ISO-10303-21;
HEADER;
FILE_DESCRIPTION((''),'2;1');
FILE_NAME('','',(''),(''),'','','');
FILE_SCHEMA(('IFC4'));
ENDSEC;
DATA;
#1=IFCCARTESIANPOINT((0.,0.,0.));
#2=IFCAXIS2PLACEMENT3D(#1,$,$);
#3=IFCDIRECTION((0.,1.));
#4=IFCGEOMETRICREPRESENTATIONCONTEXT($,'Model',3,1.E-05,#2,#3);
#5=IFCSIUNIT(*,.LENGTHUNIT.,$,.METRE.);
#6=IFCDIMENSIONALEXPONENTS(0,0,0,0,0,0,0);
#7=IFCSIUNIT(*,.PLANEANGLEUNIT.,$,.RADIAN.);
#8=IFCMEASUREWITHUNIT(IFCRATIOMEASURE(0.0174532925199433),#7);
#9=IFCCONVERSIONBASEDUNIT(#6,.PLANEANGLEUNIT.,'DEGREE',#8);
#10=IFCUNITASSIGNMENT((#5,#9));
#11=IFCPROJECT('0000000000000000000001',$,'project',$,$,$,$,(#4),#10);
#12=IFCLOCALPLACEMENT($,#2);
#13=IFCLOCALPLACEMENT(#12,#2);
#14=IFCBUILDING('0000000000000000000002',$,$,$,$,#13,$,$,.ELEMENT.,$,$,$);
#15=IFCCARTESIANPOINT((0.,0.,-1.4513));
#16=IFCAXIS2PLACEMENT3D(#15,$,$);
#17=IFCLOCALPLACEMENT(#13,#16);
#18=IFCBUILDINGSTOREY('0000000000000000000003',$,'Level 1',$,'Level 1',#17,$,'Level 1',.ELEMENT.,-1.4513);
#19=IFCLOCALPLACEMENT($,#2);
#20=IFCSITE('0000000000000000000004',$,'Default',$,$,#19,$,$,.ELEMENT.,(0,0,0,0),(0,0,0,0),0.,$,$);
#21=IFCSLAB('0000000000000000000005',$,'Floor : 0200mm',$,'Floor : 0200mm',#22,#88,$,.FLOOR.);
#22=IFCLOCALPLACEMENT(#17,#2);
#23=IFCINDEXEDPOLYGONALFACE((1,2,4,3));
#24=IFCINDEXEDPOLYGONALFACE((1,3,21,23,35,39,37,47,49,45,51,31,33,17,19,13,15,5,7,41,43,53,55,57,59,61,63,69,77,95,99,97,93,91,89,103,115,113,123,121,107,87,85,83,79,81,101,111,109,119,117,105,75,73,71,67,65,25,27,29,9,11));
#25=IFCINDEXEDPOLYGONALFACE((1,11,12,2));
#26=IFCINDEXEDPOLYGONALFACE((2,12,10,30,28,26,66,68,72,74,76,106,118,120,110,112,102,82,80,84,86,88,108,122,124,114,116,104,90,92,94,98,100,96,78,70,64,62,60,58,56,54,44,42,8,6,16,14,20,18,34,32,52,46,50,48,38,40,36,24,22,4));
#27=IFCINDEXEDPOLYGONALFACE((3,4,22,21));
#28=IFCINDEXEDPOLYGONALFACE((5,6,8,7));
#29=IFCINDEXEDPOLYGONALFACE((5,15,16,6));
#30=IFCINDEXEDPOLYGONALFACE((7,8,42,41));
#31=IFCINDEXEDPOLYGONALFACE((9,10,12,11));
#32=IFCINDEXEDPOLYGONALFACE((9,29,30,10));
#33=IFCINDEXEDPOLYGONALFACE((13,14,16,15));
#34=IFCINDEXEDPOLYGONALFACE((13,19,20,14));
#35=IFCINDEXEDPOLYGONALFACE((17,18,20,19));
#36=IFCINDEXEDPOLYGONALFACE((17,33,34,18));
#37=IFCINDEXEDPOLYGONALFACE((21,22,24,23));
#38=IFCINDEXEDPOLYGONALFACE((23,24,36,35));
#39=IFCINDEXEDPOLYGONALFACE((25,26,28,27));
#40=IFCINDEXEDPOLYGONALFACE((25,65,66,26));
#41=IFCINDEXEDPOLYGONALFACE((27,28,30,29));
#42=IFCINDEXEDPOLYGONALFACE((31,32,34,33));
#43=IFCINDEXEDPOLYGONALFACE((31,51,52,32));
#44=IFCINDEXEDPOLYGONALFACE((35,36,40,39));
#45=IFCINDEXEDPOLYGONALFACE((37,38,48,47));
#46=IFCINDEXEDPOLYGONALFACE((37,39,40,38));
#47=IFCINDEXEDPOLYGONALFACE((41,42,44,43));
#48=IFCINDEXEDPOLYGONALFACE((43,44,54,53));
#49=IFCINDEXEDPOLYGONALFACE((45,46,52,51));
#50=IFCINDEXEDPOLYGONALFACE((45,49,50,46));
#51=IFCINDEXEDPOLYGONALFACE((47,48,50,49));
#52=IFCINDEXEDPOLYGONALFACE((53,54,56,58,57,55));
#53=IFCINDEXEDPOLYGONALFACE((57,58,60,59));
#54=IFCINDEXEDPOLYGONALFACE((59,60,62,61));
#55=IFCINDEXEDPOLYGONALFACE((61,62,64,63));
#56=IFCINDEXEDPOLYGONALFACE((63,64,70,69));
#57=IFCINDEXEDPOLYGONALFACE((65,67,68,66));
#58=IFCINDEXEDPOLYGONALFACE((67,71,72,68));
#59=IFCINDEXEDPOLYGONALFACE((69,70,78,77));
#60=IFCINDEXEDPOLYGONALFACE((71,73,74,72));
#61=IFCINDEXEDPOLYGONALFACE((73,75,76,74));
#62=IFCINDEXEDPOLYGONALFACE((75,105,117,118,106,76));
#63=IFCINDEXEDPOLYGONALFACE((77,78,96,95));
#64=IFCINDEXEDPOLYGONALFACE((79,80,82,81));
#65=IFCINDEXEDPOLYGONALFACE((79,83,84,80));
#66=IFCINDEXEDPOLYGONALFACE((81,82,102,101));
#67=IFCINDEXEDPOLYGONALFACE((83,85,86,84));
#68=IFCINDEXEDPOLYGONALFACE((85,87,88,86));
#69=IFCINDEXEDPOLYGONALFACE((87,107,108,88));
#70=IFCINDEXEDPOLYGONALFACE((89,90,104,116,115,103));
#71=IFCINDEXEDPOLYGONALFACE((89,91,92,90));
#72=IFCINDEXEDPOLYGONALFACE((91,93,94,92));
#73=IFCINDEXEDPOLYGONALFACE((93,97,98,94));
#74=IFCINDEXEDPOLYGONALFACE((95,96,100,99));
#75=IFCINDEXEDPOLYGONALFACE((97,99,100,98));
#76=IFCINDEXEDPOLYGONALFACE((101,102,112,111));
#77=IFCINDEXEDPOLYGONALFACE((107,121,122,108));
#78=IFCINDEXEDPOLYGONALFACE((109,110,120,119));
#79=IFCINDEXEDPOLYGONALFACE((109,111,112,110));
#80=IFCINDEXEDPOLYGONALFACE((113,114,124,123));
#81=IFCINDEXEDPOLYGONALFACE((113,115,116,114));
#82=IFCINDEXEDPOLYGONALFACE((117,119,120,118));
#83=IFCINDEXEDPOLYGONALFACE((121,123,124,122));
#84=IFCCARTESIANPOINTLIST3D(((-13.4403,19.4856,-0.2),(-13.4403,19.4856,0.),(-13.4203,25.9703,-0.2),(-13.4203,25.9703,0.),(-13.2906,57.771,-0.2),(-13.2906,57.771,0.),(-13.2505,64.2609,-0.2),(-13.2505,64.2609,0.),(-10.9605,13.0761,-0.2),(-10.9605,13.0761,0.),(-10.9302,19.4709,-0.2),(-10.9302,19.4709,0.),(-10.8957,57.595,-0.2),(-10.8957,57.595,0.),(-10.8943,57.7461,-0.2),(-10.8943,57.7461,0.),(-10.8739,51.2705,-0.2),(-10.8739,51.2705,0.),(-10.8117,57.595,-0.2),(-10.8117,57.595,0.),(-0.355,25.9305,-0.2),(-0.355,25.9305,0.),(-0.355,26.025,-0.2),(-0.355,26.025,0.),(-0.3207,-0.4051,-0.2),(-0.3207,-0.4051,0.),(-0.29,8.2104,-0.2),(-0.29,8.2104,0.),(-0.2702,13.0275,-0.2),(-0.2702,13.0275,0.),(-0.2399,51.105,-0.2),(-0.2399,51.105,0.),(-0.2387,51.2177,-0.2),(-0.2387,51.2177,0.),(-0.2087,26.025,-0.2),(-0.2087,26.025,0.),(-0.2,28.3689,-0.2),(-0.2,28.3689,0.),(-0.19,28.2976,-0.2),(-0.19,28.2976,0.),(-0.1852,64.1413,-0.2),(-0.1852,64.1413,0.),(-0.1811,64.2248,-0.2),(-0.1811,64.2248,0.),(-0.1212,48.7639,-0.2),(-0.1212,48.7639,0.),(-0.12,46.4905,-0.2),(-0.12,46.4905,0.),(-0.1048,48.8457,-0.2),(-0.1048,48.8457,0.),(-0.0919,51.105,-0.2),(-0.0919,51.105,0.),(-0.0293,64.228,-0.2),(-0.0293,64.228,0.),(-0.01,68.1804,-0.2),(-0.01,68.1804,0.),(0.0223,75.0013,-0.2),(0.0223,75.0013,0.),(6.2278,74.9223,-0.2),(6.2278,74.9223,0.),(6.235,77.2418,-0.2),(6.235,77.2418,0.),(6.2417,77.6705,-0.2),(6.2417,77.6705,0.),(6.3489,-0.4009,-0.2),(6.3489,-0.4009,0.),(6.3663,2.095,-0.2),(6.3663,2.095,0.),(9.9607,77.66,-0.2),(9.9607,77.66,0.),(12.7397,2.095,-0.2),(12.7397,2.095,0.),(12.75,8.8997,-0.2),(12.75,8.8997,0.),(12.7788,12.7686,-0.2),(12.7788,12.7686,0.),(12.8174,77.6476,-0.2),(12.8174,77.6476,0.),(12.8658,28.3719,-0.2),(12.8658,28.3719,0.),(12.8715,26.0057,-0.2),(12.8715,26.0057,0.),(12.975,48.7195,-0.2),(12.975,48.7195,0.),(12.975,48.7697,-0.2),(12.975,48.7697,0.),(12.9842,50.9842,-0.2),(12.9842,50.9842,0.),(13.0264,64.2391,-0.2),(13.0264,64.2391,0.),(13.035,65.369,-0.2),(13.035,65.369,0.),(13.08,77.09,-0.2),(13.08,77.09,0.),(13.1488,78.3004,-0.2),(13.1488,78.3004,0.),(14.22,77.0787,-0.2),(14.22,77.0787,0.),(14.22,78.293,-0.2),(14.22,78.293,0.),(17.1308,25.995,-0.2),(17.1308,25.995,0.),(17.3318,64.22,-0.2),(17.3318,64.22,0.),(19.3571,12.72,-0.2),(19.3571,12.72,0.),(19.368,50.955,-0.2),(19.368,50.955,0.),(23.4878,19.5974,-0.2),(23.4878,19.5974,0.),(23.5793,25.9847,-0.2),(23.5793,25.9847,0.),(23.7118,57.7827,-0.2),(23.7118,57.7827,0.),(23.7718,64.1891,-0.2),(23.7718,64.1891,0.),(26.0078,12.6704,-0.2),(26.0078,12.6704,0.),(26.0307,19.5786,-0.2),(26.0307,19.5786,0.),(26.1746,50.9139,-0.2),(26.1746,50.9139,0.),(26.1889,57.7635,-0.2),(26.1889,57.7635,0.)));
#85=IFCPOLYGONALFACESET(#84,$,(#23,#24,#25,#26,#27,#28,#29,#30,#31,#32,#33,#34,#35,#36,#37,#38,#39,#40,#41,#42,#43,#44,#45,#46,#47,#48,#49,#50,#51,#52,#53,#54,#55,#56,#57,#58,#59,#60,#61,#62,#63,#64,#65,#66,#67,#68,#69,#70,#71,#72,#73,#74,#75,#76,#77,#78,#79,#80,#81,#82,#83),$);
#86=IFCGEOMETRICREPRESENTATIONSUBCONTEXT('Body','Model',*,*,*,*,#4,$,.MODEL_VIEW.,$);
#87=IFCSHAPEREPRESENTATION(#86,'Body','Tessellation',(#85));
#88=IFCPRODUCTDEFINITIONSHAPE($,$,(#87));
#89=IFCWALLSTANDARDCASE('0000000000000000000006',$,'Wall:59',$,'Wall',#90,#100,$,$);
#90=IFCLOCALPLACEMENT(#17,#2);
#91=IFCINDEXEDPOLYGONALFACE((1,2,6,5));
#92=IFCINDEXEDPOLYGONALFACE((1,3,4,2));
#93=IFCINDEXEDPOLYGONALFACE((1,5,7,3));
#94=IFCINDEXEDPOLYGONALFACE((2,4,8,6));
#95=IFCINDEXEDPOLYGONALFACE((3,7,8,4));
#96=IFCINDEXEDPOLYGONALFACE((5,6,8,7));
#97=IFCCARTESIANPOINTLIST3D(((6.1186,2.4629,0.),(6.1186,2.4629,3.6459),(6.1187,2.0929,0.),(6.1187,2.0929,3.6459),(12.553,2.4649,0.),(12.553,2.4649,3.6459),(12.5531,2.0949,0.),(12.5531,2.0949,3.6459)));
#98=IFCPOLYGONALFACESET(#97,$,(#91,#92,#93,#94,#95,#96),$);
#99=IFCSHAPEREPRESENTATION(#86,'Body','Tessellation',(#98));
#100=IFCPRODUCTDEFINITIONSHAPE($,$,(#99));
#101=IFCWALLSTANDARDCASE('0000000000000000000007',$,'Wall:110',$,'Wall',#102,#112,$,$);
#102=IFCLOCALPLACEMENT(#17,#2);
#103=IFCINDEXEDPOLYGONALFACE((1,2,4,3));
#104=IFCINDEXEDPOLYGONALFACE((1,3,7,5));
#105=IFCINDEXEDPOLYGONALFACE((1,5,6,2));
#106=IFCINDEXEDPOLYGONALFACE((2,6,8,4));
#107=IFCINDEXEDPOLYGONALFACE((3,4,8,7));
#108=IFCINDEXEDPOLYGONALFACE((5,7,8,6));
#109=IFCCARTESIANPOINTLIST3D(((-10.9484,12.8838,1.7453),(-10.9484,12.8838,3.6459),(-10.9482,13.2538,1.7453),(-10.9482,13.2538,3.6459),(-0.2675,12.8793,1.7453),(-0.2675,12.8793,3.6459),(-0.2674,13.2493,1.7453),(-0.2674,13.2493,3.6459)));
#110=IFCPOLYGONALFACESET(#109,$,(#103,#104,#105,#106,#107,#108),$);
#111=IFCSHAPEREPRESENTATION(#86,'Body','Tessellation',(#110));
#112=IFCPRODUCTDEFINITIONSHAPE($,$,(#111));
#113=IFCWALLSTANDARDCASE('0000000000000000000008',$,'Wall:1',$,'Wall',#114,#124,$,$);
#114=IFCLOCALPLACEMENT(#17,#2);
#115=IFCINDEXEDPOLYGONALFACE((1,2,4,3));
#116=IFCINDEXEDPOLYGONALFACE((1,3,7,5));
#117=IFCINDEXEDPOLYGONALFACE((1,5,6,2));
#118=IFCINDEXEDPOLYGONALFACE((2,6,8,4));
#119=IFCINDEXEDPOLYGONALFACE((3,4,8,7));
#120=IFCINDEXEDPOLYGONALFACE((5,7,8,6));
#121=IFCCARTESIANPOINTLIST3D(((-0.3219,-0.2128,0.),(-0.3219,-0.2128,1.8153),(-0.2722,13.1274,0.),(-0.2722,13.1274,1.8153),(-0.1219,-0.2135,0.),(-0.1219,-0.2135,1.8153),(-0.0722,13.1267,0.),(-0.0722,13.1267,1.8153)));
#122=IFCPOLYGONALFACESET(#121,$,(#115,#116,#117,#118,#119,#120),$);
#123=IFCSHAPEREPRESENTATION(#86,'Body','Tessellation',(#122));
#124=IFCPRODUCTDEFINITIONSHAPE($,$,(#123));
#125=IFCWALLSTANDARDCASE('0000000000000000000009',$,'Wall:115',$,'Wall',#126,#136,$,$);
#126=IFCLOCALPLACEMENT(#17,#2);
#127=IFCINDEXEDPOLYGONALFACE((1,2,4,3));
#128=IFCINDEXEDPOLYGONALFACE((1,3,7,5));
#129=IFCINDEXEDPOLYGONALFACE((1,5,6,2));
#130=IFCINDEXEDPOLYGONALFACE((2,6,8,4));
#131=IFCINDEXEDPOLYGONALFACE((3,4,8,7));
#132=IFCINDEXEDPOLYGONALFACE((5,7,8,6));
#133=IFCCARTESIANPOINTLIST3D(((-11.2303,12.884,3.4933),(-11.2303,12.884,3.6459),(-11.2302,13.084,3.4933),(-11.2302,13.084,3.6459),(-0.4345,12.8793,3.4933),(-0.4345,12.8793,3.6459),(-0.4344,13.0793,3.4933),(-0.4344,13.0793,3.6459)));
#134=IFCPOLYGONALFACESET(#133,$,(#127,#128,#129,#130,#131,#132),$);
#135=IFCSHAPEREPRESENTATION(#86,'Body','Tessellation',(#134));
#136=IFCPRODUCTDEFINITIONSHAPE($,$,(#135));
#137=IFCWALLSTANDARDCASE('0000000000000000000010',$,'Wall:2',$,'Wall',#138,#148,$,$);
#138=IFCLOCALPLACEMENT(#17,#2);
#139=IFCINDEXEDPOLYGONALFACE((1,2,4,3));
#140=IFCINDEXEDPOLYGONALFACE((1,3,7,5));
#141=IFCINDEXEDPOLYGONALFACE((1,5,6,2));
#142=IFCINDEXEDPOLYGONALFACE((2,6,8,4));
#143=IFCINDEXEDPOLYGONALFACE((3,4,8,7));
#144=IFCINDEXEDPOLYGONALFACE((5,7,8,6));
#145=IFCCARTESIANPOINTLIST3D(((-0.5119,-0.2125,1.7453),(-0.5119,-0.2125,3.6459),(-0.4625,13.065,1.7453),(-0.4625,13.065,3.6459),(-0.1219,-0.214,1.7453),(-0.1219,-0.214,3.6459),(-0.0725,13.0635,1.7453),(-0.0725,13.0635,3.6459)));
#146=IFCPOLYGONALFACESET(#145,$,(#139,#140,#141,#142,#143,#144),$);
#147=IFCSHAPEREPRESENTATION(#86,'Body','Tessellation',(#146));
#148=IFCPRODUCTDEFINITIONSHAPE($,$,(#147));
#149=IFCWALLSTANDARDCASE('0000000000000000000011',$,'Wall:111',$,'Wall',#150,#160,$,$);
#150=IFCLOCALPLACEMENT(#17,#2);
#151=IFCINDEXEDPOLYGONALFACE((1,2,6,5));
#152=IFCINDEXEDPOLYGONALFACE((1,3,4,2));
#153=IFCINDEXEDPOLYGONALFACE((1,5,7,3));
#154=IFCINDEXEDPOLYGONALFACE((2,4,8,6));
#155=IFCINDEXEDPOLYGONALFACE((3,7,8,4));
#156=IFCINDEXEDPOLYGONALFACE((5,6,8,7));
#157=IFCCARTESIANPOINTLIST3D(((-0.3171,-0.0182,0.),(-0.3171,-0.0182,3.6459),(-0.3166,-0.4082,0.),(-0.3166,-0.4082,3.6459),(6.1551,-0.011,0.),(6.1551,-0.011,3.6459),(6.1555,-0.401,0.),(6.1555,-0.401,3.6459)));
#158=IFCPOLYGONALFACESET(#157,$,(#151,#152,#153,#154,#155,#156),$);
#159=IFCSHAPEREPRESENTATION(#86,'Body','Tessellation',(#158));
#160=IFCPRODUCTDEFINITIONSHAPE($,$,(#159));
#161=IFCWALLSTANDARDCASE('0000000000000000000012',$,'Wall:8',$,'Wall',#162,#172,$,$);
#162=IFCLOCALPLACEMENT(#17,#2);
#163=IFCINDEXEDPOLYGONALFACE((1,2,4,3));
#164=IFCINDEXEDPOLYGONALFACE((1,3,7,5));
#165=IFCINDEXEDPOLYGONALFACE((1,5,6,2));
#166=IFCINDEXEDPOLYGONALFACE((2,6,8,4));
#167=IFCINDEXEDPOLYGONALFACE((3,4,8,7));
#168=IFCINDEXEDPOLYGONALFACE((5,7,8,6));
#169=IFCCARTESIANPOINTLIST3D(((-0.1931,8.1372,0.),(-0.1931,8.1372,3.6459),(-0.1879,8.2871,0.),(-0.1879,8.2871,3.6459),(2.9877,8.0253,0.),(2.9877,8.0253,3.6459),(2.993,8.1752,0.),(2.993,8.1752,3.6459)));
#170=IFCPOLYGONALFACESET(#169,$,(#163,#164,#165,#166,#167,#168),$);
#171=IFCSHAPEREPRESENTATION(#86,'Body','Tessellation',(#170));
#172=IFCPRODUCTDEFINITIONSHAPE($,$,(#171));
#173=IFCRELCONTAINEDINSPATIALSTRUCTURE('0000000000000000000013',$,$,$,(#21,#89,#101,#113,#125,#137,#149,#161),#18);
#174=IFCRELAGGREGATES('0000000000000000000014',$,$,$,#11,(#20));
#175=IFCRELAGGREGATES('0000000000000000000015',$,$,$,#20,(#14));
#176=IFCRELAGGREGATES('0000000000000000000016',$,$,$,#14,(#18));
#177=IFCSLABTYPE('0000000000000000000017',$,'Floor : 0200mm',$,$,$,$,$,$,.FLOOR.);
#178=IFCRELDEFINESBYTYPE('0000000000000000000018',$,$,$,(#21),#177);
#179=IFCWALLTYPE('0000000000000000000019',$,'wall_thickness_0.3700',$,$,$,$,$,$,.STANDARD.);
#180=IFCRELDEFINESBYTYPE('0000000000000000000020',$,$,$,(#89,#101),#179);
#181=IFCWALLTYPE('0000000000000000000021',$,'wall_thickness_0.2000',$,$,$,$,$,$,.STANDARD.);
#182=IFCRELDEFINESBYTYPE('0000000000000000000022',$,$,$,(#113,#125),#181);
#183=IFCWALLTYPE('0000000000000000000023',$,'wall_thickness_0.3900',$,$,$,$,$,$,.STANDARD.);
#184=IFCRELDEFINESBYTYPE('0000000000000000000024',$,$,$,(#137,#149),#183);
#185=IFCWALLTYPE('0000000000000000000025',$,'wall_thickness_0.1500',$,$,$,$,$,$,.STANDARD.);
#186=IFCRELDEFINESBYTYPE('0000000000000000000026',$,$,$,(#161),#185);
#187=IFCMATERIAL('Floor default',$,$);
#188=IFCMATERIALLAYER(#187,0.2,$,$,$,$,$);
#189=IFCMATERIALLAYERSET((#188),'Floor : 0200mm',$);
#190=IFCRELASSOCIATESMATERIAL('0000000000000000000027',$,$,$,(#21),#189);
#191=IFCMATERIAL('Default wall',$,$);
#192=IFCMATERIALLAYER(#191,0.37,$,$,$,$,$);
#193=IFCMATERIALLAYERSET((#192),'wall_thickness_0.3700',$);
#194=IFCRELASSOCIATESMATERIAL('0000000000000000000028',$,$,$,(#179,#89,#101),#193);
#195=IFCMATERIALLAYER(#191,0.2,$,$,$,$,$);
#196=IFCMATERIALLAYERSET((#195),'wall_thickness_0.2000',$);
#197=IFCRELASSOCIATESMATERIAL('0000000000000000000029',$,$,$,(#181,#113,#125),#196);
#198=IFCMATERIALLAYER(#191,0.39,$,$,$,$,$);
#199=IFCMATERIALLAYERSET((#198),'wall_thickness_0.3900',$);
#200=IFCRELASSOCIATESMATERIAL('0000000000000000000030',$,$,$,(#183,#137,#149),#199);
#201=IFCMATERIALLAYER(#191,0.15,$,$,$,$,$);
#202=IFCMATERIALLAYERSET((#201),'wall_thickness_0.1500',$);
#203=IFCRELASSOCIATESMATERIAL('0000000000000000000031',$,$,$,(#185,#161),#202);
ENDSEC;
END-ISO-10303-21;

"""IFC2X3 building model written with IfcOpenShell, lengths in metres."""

from ifc_helpers import new_model, entity, si_unit, converted_unit, direction, frame, origin, place, context, subcontext, project, spatial, polyline, outline, extrude, material, layer, layer_set, layer_usage, type_object, element, save


model = new_model("IFC2X3")

# Units and contexts
model_context = context("Model", 3, precision=1e-05, world=origin(), true_north=direction((0.0, 1.0)))
body_context = subcontext(model_context, "Body", "Model", "MODEL_VIEW")
ifc_project = project(units=[si_unit("LENGTHUNIT", "METRE"), converted_unit("PLANEANGLEUNIT", "DEGREE", entity("IfcRatioMeasure", 0.0174532925199433), si_unit("PLANEANGLEUNIT", "RADIAN"), dimensions=[0, 0, 0, 0, 0, 0, 0])], contexts=[model_context])

# Site, building, storey
site_placement = place(None, origin())
site = spatial("IfcSite", under=ifc_project, at=site_placement, Name="Default", CompositionType="ELEMENT", RefLatitude=(0, 0, 0, 0), RefLongitude=(0, 0, 0, 0), RefElevation=0.0)
placement_1 = place(None, origin())
building_placement = place(placement_1, origin())
building = spatial("IfcBuilding", under=site, at=building_placement, CompositionType="ELEMENT")
storey_placement = place(building_placement, frame((0.0, 0.0, -1.4513)))
storey = spatial("IfcBuildingStorey", under=building, at=storey_placement, Name="Level 1", ObjectType="Level 1", LongName="Level 1", CompositionType="ELEMENT", Elevation=-1.4513)

# Slab
ifc_material_1 = material(Name="Floor default")
ifc_layer_1 = layer(ifc_material_1, 0.2)
ifc_layer_set_1 = layer_set([ifc_layer_1], Name="Floor : 0200mm")
ifc_layer_usage_1 = layer_usage(ifc_layer_set_1, "AXIS3", "POSITIVE", 0.0)
slab_type = type_object("IfcSlabType", Name="Floor : 0200mm", PredefinedType="FLOOR")
slab_placement = place(storey_placement, origin())
element("IfcSlab", 1, at=slab_placement, inside=storey, type_object=slab_type, material=ifc_layer_usage_1, Name="Floor : 0200mm", ObjectType="Floor : 0200mm", PredefinedType="FLOOR", context=body_context, shape_type="SweptSolid", body=[
    extrude(outline(polyline([(6.3489, -0.4009), (6.3663, 2.095), (12.7397, 2.095), (12.75, 8.8997), (12.7788, 12.7686), (19.3571, 12.72), (26.0078, 12.6704), (26.0307, 19.5786), (23.4878, 19.5974), (23.5793, 25.9847), (17.1308, 25.995), (12.8715, 26.0057), (12.8658, 28.3719), (12.975, 48.7195), (12.975, 48.7697), (12.9842, 50.9842), (19.368, 50.955), (26.1746, 50.9139), (26.1889, 57.7635), (23.7118, 57.7827), (23.7718, 64.1891), (17.3318, 64.22), (13.0264, 64.2391), (13.035, 65.369), (13.08, 77.09), (14.22, 77.0787), (14.22, 78.293), (13.1488, 78.3004), (12.8174, 77.6476), (9.9607, 77.66), (6.2417, 77.6705), (6.235, 77.2418), (6.2278, 74.9223), (0.0223, 75.0013), (-0.01, 68.1804), (-0.0293, 64.228), (-0.1811, 64.2248), (-0.1852, 64.1413), (-13.2505, 64.2609), (-13.2906, 57.771), (-10.8943, 57.7461), (-10.8957, 57.595), (-10.8117, 57.595), (-10.8739, 51.2705), (-0.2387, 51.2177), (-0.2399, 51.105), (-0.0919, 51.105), (-0.1212, 48.7639), (-0.1048, 48.8457), (-0.12, 46.4905), (-0.2, 28.3689), (-0.19, 28.2976), (-0.2087, 26.025), (-0.355, 26.025), (-0.355, 25.9305), (-13.4203, 25.9703), (-13.4403, 19.4856), (-10.9302, 19.4709), (-10.9605, 13.0761), (-0.2702, 13.0275), (-0.29, 8.2104), (-0.3207, -0.4051), (6.3489, -0.4009)])), frame((0.0, 0.0, -0.2), z_axis=(0.0, 0.0, 1.0), x_axis=(1.0, 0.0, 0.0)), (0.0, 0.0, 1.0), 0.2),
])

# Walls
ifc_material_2 = material(Name="Default wall")
ifc_layer_2 = layer(ifc_material_2, 0.37)
ifc_layer_set_2 = layer_set([ifc_layer_2], Name="wall_thickness_0.3700")
ifc_layer_usage_2 = layer_usage(ifc_layer_set_2, "AXIS2", "POSITIVE", -0.185)
wall_type_1 = type_object("IfcWallType", Name="wall_thickness_0.3700", PredefinedType="STANDARD", material=ifc_layer_set_2)
wall_1_placement = place(storey_placement, frame((6.1187, 2.2779, 0.0), z_axis=(0.0, 0.0, 1.0), x_axis=(1.0, 0.000303, 0.0)))
element("IfcWallStandardCase", 2, at=wall_1_placement, inside=storey, type_object=wall_type_1, material=ifc_layer_usage_2, Name="Wall:59", ObjectType="Wall", context=body_context, shape_type="SweptSolid", body=[
    extrude(outline(polyline([(6.4344, -0.185), (6.4344, 0.185), (0.0, 0.185), (0.0, -0.185), (6.4344, -0.185)])), origin(), (0.0, 0.0, 1.0), 3.6459),
])
placement_2 = place(building_placement, frame((0.0, 0.0, 0.294)))
wall_2_placement = place(placement_2, frame((-10.9483, 13.0688, 0.0), z_axis=(0.0, 0.0, 1.0), x_axis=(1.0, -0.000429, 0.0)))
element("IfcWallStandardCase", 3, at=wall_2_placement, inside=storey, type_object=wall_type_1, material=ifc_layer_usage_2, Name="Wall:110", ObjectType="Wall", context=body_context, shape_type="SweptSolid", body=[
    extrude(outline(polyline([(10.6808, -0.185), (10.6808, 0.185), (0.0, 0.185), (0.0, -0.185), (10.6808, -0.185)])), origin(), (0.0, 0.0, 1.0), 1.9006),
])
ifc_layer_3 = layer(ifc_material_2, 0.2)
ifc_layer_set_3 = layer_set([ifc_layer_3], Name="wall_thickness_0.2000")
ifc_layer_usage_3 = layer_usage(ifc_layer_set_3, "AXIS2", "POSITIVE", -0.1)
wall_type_2 = type_object("IfcWallType", Name="wall_thickness_0.2000", PredefinedType="STANDARD", material=ifc_layer_set_3)
wall_3_placement = place(storey_placement, frame((-0.1722, 13.127, 0.0), z_axis=(0.0, 0.0, 1.0), x_axis=(-0.00372, -0.999993, 0.0)))
element("IfcWallStandardCase", 4, at=wall_3_placement, inside=storey, type_object=wall_type_2, material=ifc_layer_usage_3, Name="Wall:1", ObjectType="Wall", context=body_context, shape_type="SweptSolid", body=[
    extrude(outline(polyline([(13.3403, -0.1), (13.3403, 0.1), (0.0, 0.1), (0.0, -0.1), (13.3403, -0.1)])), origin(), (0.0, 0.0, 1.0), 1.8153),
])
placement_3 = place(building_placement, frame((0.0, 0.0, 2.042)))
wall_4_placement = place(placement_3, frame((-11.2302, 12.984, 0.0), z_axis=(0.0, 0.0, 1.0), x_axis=(1.0, -0.000429, 0.0)))
element("IfcWallStandardCase", 5, at=wall_4_placement, inside=storey, type_object=wall_type_2, material=ifc_layer_usage_3, Name="Wall:115", ObjectType="Wall", context=body_context, shape_type="SweptSolid", body=[
    extrude(outline(polyline([(10.7957, -0.1), (10.7957, 0.1), (0.0, 0.1), (0.0, -0.1), (10.7957, -0.1)])), origin(), (0.0, 0.0, 1.0), 0.1526),
])
ifc_layer_4 = layer(ifc_material_2, 0.39)
ifc_layer_set_4 = layer_set([ifc_layer_4], Name="wall_thickness_0.3900")
ifc_layer_usage_4 = layer_usage(ifc_layer_set_4, "AXIS2", "POSITIVE", -0.195)
wall_type_3 = type_object("IfcWallType", Name="wall_thickness_0.3900", PredefinedType="STANDARD", material=ifc_layer_set_4)
placement_4 = place(building_placement, frame((0.0, 0.0, 0.294)))
wall_5_placement = place(placement_4, frame((-0.2675, 13.0643, 0.0), z_axis=(0.0, 0.0, 1.0), x_axis=(-0.00372, -0.999993, 0.0)))
element("IfcWallStandardCase", 6, at=wall_5_placement, inside=storey, type_object=wall_type_3, material=ifc_layer_usage_4, Name="Wall:2", ObjectType="Wall", context=body_context, shape_type="SweptSolid", body=[
    extrude(outline(polyline([(13.2776, -0.195), (13.2776, 0.195), (0.0, 0.195), (0.0, -0.195), (13.2776, -0.195)])), origin(), (0.0, 0.0, 1.0), 1.9006),
])
wall_6_placement = place(storey_placement, frame((-0.3169, -0.2132, 0.0), z_axis=(0.0, 0.0, 1.0), x_axis=(0.999999, 0.001121, 0.0)))
element("IfcWallStandardCase", 7, at=wall_6_placement, inside=storey, type_object=wall_type_3, material=ifc_layer_usage_4, Name="Wall:111", ObjectType="Wall", context=body_context, shape_type="SweptSolid", body=[
    extrude(outline(polyline([(6.4721, -0.195), (6.4721, 0.195), (0.0, 0.195), (0.0, -0.195), (6.4721, -0.195)])), origin(), (0.0, 0.0, 1.0), 3.6459),
])
ifc_layer_5 = layer(ifc_material_2, 0.15)
ifc_layer_set_5 = layer_set([ifc_layer_5], Name="wall_thickness_0.1500")
ifc_layer_usage_5 = layer_usage(ifc_layer_set_5, "AXIS2", "POSITIVE", -0.075)
wall_type_4 = type_object("IfcWallType", Name="wall_thickness_0.1500", PredefinedType="STANDARD", material=ifc_layer_set_5)
wall_7_placement = place(storey_placement, frame((-0.1905, 8.2122, 0.0), z_axis=(0.0, 0.0, 1.0), x_axis=(0.999382, -0.035165, 0.0)))
element("IfcWallStandardCase", 8, at=wall_7_placement, inside=storey, type_object=wall_type_4, material=ifc_layer_usage_5, Name="Wall:8", ObjectType="Wall", context=body_context, shape_type="SweptSolid", body=[
    extrude(outline(polyline([(3.1828, -0.075), (3.1828, 0.075), (0.0, 0.075), (0.0, -0.075), (3.1828, -0.075)])), origin(), (0.0, 0.0, 1.0), 3.6459),
])

save(model, "model.ifc")
